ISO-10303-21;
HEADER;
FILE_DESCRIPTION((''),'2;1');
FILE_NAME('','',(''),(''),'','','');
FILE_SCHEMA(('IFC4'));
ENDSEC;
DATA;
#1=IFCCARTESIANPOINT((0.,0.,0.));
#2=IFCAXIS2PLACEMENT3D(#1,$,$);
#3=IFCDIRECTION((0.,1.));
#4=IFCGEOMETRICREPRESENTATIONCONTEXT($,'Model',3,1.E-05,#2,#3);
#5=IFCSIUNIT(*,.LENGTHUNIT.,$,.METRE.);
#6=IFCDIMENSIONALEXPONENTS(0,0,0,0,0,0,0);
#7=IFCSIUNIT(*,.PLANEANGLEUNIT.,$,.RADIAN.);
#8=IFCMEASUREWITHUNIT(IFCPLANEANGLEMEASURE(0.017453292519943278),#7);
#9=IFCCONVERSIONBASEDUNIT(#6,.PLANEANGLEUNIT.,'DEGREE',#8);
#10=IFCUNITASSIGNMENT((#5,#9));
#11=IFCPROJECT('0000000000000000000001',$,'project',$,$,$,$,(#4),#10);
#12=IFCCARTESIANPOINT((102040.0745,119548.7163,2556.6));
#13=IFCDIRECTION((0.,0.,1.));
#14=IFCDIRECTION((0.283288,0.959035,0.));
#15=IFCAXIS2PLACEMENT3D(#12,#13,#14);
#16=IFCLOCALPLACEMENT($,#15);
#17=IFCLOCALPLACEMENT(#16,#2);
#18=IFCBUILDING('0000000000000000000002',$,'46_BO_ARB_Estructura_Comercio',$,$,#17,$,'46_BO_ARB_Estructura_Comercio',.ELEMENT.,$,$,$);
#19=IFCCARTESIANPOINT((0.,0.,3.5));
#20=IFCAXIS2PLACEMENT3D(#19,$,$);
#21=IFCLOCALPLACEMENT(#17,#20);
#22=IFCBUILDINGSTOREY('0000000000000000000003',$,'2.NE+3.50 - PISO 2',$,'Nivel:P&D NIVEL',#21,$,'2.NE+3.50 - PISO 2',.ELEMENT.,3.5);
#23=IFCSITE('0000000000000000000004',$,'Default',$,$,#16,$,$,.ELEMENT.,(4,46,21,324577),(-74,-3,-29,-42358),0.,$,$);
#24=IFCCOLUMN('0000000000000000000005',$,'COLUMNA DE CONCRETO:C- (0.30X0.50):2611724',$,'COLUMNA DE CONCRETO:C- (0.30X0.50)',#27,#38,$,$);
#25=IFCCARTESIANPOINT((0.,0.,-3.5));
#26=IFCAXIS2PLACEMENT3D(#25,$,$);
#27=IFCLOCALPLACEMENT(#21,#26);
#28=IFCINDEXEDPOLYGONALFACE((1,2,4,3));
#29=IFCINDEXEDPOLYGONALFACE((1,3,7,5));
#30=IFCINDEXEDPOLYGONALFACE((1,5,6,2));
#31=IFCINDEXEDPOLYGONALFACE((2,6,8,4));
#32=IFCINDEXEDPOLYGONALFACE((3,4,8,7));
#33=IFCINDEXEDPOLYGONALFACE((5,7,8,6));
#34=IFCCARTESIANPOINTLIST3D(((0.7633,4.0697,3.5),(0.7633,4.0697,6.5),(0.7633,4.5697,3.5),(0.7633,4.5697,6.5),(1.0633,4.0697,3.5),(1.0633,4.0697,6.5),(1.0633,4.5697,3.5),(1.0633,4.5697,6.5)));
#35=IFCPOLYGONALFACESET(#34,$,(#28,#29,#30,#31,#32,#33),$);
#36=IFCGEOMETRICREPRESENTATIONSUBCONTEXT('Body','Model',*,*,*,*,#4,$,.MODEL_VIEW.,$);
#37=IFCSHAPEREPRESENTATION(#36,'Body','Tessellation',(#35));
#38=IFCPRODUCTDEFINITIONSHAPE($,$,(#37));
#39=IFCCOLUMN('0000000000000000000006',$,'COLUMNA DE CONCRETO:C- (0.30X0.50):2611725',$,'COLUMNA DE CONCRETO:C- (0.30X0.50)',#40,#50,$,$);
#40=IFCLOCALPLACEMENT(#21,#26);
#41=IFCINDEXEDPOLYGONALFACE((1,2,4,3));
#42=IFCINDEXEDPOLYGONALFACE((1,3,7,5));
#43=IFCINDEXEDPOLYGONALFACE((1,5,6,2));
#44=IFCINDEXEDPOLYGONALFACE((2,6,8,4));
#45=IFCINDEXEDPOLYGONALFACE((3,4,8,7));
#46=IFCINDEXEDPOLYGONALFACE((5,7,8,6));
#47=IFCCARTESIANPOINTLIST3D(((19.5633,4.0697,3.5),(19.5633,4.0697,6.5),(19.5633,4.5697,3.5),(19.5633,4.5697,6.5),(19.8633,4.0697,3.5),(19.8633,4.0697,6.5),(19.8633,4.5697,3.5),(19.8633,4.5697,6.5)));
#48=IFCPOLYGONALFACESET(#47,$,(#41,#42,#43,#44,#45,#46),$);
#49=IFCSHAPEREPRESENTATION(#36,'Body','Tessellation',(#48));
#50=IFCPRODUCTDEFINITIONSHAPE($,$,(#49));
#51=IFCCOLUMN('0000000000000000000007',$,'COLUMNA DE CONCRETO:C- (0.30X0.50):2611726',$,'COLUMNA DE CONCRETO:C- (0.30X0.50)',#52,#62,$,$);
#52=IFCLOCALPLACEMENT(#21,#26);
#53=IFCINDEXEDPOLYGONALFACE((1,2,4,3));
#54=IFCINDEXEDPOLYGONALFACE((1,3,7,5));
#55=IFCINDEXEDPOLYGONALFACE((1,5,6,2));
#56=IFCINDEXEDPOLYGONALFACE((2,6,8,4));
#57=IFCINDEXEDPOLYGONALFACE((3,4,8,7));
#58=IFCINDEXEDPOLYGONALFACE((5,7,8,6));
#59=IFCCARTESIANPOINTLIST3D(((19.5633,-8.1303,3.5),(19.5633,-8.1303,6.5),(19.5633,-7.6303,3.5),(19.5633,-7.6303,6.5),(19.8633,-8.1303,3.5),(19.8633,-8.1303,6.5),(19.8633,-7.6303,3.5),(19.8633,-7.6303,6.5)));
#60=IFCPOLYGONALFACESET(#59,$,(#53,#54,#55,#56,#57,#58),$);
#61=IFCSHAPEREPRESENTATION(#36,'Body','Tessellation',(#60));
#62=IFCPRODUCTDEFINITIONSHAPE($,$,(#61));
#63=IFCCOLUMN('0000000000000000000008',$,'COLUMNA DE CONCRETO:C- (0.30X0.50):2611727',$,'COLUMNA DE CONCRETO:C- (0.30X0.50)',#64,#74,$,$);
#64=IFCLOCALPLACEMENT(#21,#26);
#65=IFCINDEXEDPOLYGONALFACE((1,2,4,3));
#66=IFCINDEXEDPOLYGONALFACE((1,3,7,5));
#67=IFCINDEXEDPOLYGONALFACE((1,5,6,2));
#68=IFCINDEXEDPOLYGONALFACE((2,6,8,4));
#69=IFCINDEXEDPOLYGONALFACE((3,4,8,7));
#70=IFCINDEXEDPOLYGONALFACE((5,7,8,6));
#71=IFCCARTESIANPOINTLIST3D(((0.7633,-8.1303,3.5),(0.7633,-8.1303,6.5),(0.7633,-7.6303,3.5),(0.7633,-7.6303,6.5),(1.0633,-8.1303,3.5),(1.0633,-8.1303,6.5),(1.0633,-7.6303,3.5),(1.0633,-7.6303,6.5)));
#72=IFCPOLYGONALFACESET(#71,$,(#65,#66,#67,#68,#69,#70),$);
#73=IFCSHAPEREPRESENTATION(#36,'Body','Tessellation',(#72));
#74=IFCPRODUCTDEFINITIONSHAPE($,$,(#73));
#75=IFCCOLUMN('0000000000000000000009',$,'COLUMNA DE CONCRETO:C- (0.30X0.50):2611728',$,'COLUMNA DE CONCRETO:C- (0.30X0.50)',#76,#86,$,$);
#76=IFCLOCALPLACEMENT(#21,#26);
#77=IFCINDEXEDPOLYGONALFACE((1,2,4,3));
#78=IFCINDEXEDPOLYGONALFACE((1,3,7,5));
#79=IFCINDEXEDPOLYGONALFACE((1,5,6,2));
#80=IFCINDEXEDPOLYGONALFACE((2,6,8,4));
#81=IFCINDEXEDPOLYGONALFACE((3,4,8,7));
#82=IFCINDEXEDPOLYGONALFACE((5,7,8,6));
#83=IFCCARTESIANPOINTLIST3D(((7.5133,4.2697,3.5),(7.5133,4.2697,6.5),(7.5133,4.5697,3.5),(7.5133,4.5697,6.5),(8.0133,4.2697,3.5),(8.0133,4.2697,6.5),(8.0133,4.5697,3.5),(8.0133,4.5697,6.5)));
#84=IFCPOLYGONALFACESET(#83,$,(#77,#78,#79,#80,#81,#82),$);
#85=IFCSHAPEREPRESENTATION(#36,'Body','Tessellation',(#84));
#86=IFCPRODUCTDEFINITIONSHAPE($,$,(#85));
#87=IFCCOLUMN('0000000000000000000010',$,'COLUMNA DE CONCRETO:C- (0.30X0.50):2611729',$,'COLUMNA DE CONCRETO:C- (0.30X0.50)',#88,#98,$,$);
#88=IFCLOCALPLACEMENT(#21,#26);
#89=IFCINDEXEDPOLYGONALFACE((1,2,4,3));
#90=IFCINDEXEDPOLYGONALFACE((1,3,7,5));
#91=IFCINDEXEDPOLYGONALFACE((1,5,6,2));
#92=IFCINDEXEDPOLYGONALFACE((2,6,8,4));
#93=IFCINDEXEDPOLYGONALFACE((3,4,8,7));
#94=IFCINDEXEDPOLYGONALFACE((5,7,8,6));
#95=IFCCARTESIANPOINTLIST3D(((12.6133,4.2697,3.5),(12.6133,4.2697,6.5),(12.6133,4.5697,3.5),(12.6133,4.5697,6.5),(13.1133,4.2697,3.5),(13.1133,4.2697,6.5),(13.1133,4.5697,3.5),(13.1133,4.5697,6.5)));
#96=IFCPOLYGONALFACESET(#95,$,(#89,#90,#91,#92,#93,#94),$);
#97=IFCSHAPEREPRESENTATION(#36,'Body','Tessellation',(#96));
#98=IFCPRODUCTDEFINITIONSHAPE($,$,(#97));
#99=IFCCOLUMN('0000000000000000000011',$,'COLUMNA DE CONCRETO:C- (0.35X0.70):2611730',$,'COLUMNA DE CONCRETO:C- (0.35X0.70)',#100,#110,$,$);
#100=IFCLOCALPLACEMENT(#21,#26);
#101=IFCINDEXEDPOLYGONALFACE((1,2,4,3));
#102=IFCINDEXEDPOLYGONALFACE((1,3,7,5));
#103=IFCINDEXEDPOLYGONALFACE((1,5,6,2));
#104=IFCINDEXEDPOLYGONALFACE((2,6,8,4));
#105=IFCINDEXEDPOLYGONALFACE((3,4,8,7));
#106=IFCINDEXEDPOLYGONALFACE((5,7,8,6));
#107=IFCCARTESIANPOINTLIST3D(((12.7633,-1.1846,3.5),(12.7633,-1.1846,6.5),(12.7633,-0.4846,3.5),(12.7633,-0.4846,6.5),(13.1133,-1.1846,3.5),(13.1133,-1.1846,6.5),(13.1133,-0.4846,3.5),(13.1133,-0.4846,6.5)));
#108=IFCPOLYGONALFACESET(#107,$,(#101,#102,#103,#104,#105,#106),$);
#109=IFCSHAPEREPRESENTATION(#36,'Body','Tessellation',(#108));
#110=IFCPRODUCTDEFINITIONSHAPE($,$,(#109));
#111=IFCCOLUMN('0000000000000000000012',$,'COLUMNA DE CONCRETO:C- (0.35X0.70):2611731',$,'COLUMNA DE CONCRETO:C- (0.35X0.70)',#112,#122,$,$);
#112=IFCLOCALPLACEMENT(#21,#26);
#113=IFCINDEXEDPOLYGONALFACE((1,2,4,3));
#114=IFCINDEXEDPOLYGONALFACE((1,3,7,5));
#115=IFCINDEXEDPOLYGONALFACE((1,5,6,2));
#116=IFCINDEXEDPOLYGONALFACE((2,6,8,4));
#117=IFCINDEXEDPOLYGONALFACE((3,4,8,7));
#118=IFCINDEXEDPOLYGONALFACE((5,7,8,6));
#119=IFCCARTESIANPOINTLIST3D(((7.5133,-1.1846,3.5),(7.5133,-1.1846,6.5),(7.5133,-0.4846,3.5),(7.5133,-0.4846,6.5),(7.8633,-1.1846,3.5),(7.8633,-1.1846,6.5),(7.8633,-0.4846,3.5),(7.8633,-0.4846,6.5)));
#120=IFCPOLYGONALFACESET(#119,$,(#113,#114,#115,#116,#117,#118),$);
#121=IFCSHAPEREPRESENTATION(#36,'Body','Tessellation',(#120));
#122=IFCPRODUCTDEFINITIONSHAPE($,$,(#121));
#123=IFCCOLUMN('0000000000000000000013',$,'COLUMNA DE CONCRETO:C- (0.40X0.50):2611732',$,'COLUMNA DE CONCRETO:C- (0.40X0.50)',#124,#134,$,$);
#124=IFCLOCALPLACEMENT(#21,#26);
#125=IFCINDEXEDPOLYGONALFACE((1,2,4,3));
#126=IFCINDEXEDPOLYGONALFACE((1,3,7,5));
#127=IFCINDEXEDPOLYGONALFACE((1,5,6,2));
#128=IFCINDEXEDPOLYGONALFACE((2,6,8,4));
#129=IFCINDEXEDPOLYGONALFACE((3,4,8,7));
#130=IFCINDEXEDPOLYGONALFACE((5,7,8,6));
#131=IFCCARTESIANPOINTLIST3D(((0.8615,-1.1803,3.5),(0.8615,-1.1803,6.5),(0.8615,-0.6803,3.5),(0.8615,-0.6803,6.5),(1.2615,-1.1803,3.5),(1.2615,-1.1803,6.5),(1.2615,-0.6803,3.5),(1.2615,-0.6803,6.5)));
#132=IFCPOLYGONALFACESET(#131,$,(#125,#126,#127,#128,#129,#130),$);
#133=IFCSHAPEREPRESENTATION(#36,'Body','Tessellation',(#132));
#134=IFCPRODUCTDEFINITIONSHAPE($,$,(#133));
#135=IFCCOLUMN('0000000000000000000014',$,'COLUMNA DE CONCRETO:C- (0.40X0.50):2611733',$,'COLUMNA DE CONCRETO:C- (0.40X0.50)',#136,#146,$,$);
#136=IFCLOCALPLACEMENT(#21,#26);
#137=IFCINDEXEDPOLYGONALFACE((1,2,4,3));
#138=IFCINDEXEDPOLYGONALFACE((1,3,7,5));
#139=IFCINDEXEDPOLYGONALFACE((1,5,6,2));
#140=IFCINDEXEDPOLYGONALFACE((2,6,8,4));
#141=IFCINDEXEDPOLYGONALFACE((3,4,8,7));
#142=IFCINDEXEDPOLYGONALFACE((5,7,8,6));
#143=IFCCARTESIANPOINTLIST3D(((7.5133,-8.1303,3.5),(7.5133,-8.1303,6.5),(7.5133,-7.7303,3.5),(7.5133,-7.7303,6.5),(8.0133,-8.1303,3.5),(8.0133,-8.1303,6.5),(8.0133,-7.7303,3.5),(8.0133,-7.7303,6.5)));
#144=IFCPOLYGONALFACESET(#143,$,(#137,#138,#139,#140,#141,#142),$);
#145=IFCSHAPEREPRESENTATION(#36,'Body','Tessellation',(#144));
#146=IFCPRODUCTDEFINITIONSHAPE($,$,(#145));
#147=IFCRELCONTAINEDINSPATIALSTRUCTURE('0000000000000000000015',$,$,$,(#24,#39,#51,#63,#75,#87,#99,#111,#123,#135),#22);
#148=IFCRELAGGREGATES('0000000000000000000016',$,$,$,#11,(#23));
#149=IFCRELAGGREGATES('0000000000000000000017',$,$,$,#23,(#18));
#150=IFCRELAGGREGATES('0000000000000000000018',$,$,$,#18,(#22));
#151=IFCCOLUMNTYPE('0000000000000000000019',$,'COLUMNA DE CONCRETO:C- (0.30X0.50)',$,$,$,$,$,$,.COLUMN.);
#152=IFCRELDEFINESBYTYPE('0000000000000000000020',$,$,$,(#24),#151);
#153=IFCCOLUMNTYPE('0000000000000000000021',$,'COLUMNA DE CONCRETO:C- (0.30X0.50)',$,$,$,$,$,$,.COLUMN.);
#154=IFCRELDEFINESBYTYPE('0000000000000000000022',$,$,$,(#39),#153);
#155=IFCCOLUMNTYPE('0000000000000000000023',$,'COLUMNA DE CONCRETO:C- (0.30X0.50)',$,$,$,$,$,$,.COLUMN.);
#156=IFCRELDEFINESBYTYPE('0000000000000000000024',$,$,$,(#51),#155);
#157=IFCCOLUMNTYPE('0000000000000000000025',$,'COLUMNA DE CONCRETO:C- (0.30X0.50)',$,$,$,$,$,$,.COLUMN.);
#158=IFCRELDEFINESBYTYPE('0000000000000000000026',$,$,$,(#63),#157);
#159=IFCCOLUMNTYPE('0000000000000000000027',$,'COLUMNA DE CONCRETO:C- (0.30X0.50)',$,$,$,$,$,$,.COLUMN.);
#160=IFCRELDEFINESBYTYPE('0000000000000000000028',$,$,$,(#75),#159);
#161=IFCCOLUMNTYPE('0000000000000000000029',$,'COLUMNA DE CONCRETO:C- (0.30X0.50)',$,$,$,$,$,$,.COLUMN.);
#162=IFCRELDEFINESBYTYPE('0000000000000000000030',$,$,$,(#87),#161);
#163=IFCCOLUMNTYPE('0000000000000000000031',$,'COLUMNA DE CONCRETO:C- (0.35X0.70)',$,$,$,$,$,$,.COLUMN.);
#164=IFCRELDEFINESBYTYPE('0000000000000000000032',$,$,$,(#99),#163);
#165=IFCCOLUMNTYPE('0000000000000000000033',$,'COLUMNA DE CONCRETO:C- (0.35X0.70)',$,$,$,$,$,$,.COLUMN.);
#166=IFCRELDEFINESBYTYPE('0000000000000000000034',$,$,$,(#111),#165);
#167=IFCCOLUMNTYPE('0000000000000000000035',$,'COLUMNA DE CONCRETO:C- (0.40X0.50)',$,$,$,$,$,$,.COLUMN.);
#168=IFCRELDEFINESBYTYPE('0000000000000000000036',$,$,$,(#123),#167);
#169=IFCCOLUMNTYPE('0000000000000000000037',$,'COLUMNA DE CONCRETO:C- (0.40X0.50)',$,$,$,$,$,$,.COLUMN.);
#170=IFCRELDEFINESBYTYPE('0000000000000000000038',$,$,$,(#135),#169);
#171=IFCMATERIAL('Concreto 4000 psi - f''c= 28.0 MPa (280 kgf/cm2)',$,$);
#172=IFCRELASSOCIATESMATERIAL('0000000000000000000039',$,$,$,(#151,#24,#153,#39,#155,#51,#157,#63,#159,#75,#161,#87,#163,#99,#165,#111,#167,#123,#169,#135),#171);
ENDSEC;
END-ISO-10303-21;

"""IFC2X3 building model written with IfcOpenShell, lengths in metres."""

from ifc_helpers import new_model, entity, si_unit, converted_unit, direction, frame, frame_2d, origin, origin_2d_with_axis, place, context, subcontext, project, spatial, rectangle, extrude, source, transform, mapped, material, type_object, type_shapes, element, save


model = new_model("IFC2X3")

# Units and contexts
model_context = context("Model", 3, precision=1e-05, world=origin(), true_north=direction((0.0, 1.0)))
body_context = subcontext(model_context, "Body", "Model", "MODEL_VIEW")
ifc_project = project(units=[si_unit("LENGTHUNIT", "METRE"), converted_unit("PLANEANGLEUNIT", "DEGREE", entity("IfcPlaneAngleMeasure", 0.017453292519943278), si_unit("PLANEANGLEUNIT", "RADIAN"), dimensions=[0, 0, 0, 0, 0, 0, 0])], contexts=[model_context])

# Site, building, storey
site_placement = place(None, frame((102040.0745, 119548.7163, 2556.6), z_axis=(0.0, 0.0, 1.0), x_axis=(0.283288, 0.959035, 0.0)))
site = spatial("IfcSite", under=ifc_project, at=site_placement, Name="Default", CompositionType="ELEMENT", RefLatitude=(4, 46, 21, 324577), RefLongitude=(-74, -3, -29, -42358), RefElevation=0.0)
building_placement = place(site_placement, origin())
building = spatial("IfcBuilding", under=site, at=building_placement, Name="46_BO_ARB_Estructura_Comercio", LongName="46_BO_ARB_Estructura_Comercio", CompositionType="ELEMENT")
storey_placement = place(building_placement, frame((0.0, 0.0, 3.5)))
storey = spatial("IfcBuildingStorey", under=building, at=storey_placement, Name="2.NE+3.50 - PISO 2", ObjectType="Nivel:P&D NIVEL", LongName="2.NE+3.50 - PISO 2", CompositionType="ELEMENT", Elevation=3.5)

# Columns
ifc_material_1 = material(Name="Concreto 4000 psi - f'c= 28.0 MPa (280 kgf/cm2)")
column_type_1 = type_object("IfcColumnType", Name="COLUMNA DE CONCRETO:C- (0.30X0.50)", PredefinedType="COLUMN", material=ifc_material_1)
shared_shape_1 = source(origin(), body_context, "Body", "SweptSolid", [
    extrude(rectangle(XDim=0.3, YDim=0.5, at=frame_2d((0.0, 0.0), x_axis=(1.0, 0.0))), frame((0.9133, 4.3197, 3.5), z_axis=(0.0, 0.0, 1.0), x_axis=(-1.0, 0.0, 0.0)), (0.0, 0.0, 1.0), 3.0),
])
type_shapes(column_type_1, [shared_shape_1])
column_1_placement = place(storey_placement, frame((0.0, 0.0, -3.5)))
element("IfcColumn", 1, at=column_1_placement, inside=storey, type_object=column_type_1, material=ifc_material_1, Name="COLUMNA DE CONCRETO:C- (0.30X0.50):2611724", ObjectType="COLUMNA DE CONCRETO:C- (0.30X0.50)", context=body_context, shape_type="MappedRepresentation", body=[
    mapped(shared_shape_1, transform((0.0, 0.0, 0.0), scale=1.0)),
])
column_type_2 = type_object("IfcColumnType", Name="COLUMNA DE CONCRETO:C- (0.30X0.50)", PredefinedType="COLUMN", material=ifc_material_1)
shared_shape_2 = source(origin(), body_context, "Body", "SweptSolid", [
    extrude(rectangle(XDim=0.3, YDim=0.5, at=origin_2d_with_axis()), frame((19.7133, 4.3197, 3.5), z_axis=(0.0, 0.0, 1.0), x_axis=(-1.0, 0.0, 0.0)), (0.0, 0.0, 1.0), 3.0),
])
type_shapes(column_type_2, [shared_shape_2])
column_2_placement = place(storey_placement, frame((0.0, 0.0, -3.5)))
element("IfcColumn", 2, at=column_2_placement, inside=storey, type_object=column_type_2, material=ifc_material_1, Name="COLUMNA DE CONCRETO:C- (0.30X0.50):2611725", ObjectType="COLUMNA DE CONCRETO:C- (0.30X0.50)", context=body_context, shape_type="MappedRepresentation", body=[
    mapped(shared_shape_2, transform((0.0, 0.0, 0.0), scale=1.0)),
])
column_type_3 = type_object("IfcColumnType", Name="COLUMNA DE CONCRETO:C- (0.30X0.50)", PredefinedType="COLUMN", material=ifc_material_1)
shared_shape_3 = source(origin(), body_context, "Body", "SweptSolid", [
    extrude(rectangle(XDim=0.3, YDim=0.5, at=frame_2d((0.0, 0.0), x_axis=(1.0, 0.0))), frame((19.7133, -7.8803, 3.5), z_axis=(0.0, 0.0, 1.0), x_axis=(-1.0, 0.0, 0.0)), (0.0, 0.0, 1.0), 3.0),
])
type_shapes(column_type_3, [shared_shape_3])
column_3_placement = place(storey_placement, frame((0.0, 0.0, -3.5)))
element("IfcColumn", 3, at=column_3_placement, inside=storey, type_object=column_type_3, material=ifc_material_1, Name="COLUMNA DE CONCRETO:C- (0.30X0.50):2611726", ObjectType="COLUMNA DE CONCRETO:C- (0.30X0.50)", context=body_context, shape_type="MappedRepresentation", body=[
    mapped(shared_shape_3, transform((0.0, 0.0, 0.0), scale=1.0)),
])
column_type_4 = type_object("IfcColumnType", Name="COLUMNA DE CONCRETO:C- (0.30X0.50)", PredefinedType="COLUMN", material=ifc_material_1)
shared_shape_4 = source(origin(), body_context, "Body", "SweptSolid", [
    extrude(rectangle(XDim=0.3, YDim=0.5, at=frame_2d((0.0, 0.0), x_axis=(1.0, 0.0))), frame((0.9133, -7.8803, 3.5), z_axis=(0.0, 0.0, 1.0), x_axis=(-1.0, 0.0, 0.0)), (0.0, 0.0, 1.0), 3.0),
])
type_shapes(column_type_4, [shared_shape_4])
column_4_placement = place(storey_placement, frame((0.0, 0.0, -3.5)))
element("IfcColumn", 4, at=column_4_placement, inside=storey, type_object=column_type_4, material=ifc_material_1, Name="COLUMNA DE CONCRETO:C- (0.30X0.50):2611727", ObjectType="COLUMNA DE CONCRETO:C- (0.30X0.50)", context=body_context, shape_type="MappedRepresentation", body=[
    mapped(shared_shape_4, transform((0.0, 0.0, 0.0), scale=1.0)),
])
column_type_5 = type_object("IfcColumnType", Name="COLUMNA DE CONCRETO:C- (0.30X0.50)", PredefinedType="COLUMN", material=ifc_material_1)
shared_shape_5 = source(origin(), body_context, "Body", "SweptSolid", [
    extrude(rectangle(XDim=0.3, YDim=0.5, at=frame_2d((0.0, 0.0), x_axis=(1.0, 0.0))), frame((7.7633, 4.4197, 3.5), z_axis=(0.0, 0.0, 1.0), x_axis=(0.0, -1.0, 0.0)), (0.0, 0.0, 1.0), 3.0),
])
type_shapes(column_type_5, [shared_shape_5])
column_5_placement = place(storey_placement, frame((0.0, 0.0, -3.5)))
element("IfcColumn", 5, at=column_5_placement, inside=storey, type_object=column_type_5, material=ifc_material_1, Name="COLUMNA DE CONCRETO:C- (0.30X0.50):2611728", ObjectType="COLUMNA DE CONCRETO:C- (0.30X0.50)", context=body_context, shape_type="MappedRepresentation", body=[
    mapped(shared_shape_5, transform((0.0, 0.0, 0.0), scale=1.0)),
])
column_type_6 = type_object("IfcColumnType", Name="COLUMNA DE CONCRETO:C- (0.30X0.50)", PredefinedType="COLUMN", material=ifc_material_1)
shared_shape_6 = source(origin(), body_context, "Body", "SweptSolid", [
    extrude(rectangle(XDim=0.3, YDim=0.5, at=frame_2d((0.0, 0.0), x_axis=(1.0, 0.0))), frame((12.8633, 4.4197, 3.5), z_axis=(0.0, 0.0, 1.0), x_axis=(0.0, -1.0, 0.0)), (0.0, 0.0, 1.0), 3.0),
])
type_shapes(column_type_6, [shared_shape_6])
column_6_placement = place(storey_placement, frame((0.0, 0.0, -3.5)))
element("IfcColumn", 6, at=column_6_placement, inside=storey, type_object=column_type_6, material=ifc_material_1, Name="COLUMNA DE CONCRETO:C- (0.30X0.50):2611729", ObjectType="COLUMNA DE CONCRETO:C- (0.30X0.50)", context=body_context, shape_type="MappedRepresentation", body=[
    mapped(shared_shape_6, transform((0.0, 0.0, 0.0), scale=1.0)),
])
column_type_7 = type_object("IfcColumnType", Name="COLUMNA DE CONCRETO:C- (0.35X0.70)", PredefinedType="COLUMN", material=ifc_material_1)
shared_shape_7 = source(origin(), body_context, "Body", "SweptSolid", [
    extrude(rectangle(XDim=0.35, YDim=0.7, at=frame_2d((0.0, 0.0), x_axis=(1.0, 0.0))), frame((12.9383, -0.8346, 3.5)), (0.0, 0.0, 1.0), 3.0),
])
type_shapes(column_type_7, [shared_shape_7])
column_7_placement = place(storey_placement, frame((0.0, 0.0, -3.5)))
element("IfcColumn", 7, at=column_7_placement, inside=storey, type_object=column_type_7, material=ifc_material_1, Name="COLUMNA DE CONCRETO:C- (0.35X0.70):2611730", ObjectType="COLUMNA DE CONCRETO:C- (0.35X0.70)", context=body_context, shape_type="MappedRepresentation", body=[
    mapped(shared_shape_7, transform((0.0, 0.0, 0.0), scale=1.0)),
])
column_type_8 = type_object("IfcColumnType", Name="COLUMNA DE CONCRETO:C- (0.35X0.70)", PredefinedType="COLUMN", material=ifc_material_1)
shared_shape_8 = source(origin(), body_context, "Body", "SweptSolid", [
    extrude(rectangle(XDim=0.7, YDim=0.35, at=frame_2d((0.0, 0.0), x_axis=(1.0, 0.0))), frame((7.6883, -0.8346, 3.5), z_axis=(0.0, 0.0, 1.0), x_axis=(0.0, 1.0, 0.0)), (0.0, 0.0, 1.0), 3.0),
])
type_shapes(column_type_8, [shared_shape_8])
column_8_placement = place(storey_placement, frame((0.0, 0.0, -3.5)))
element("IfcColumn", 8, at=column_8_placement, inside=storey, type_object=column_type_8, material=ifc_material_1, Name="COLUMNA DE CONCRETO:C- (0.35X0.70):2611731", ObjectType="COLUMNA DE CONCRETO:C- (0.35X0.70)", context=body_context, shape_type="MappedRepresentation", body=[
    mapped(shared_shape_8, transform((0.0, 0.0, 0.0), scale=1.0)),
])
column_type_9 = type_object("IfcColumnType", Name="COLUMNA DE CONCRETO:C- (0.40X0.50)", PredefinedType="COLUMN", material=ifc_material_1)
shared_shape_9 = source(origin(), body_context, "Body", "SweptSolid", [
    extrude(rectangle(XDim=0.4, YDim=0.5, at=origin_2d_with_axis()), frame((1.0615, -0.9303, 3.5), z_axis=(0.0, 0.0, 1.0), x_axis=(-1.0, 0.0, 0.0)), (0.0, 0.0, 1.0), 3.0),
])
type_shapes(column_type_9, [shared_shape_9])
column_9_placement = place(storey_placement, frame((0.0, 0.0, -3.5)))
element("IfcColumn", 9, at=column_9_placement, inside=storey, type_object=column_type_9, material=ifc_material_1, Name="COLUMNA DE CONCRETO:C- (0.40X0.50):2611732", ObjectType="COLUMNA DE CONCRETO:C- (0.40X0.50)", context=body_context, shape_type="MappedRepresentation", body=[
    mapped(shared_shape_9, transform((0.0, 0.0, 0.0), scale=1.0)),
])
column_type_10 = type_object("IfcColumnType", Name="COLUMNA DE CONCRETO:C- (0.40X0.50)", PredefinedType="COLUMN", material=ifc_material_1)
shared_shape_10 = source(origin(), body_context, "Body", "SweptSolid", [
    extrude(rectangle(XDim=0.4, YDim=0.5, at=frame_2d((0.0, 0.0), x_axis=(1.0, 0.0))), frame((7.7633, -7.9303, 3.5), z_axis=(0.0, 0.0, 1.0), x_axis=(0.0, -1.0, 0.0)), (0.0, 0.0, 1.0), 3.0),
])
type_shapes(column_type_10, [shared_shape_10])
column_10_placement = place(storey_placement, frame((0.0, 0.0, -3.5)))
element("IfcColumn", 10, at=column_10_placement, inside=storey, type_object=column_type_10, material=ifc_material_1, Name="COLUMNA DE CONCRETO:C- (0.40X0.50):2611733", ObjectType="COLUMNA DE CONCRETO:C- (0.40X0.50)", context=body_context, shape_type="MappedRepresentation", body=[
    mapped(shared_shape_10, transform((0.0, 0.0, 0.0), scale=1.0)),
])

save(model, "model.ifc")
